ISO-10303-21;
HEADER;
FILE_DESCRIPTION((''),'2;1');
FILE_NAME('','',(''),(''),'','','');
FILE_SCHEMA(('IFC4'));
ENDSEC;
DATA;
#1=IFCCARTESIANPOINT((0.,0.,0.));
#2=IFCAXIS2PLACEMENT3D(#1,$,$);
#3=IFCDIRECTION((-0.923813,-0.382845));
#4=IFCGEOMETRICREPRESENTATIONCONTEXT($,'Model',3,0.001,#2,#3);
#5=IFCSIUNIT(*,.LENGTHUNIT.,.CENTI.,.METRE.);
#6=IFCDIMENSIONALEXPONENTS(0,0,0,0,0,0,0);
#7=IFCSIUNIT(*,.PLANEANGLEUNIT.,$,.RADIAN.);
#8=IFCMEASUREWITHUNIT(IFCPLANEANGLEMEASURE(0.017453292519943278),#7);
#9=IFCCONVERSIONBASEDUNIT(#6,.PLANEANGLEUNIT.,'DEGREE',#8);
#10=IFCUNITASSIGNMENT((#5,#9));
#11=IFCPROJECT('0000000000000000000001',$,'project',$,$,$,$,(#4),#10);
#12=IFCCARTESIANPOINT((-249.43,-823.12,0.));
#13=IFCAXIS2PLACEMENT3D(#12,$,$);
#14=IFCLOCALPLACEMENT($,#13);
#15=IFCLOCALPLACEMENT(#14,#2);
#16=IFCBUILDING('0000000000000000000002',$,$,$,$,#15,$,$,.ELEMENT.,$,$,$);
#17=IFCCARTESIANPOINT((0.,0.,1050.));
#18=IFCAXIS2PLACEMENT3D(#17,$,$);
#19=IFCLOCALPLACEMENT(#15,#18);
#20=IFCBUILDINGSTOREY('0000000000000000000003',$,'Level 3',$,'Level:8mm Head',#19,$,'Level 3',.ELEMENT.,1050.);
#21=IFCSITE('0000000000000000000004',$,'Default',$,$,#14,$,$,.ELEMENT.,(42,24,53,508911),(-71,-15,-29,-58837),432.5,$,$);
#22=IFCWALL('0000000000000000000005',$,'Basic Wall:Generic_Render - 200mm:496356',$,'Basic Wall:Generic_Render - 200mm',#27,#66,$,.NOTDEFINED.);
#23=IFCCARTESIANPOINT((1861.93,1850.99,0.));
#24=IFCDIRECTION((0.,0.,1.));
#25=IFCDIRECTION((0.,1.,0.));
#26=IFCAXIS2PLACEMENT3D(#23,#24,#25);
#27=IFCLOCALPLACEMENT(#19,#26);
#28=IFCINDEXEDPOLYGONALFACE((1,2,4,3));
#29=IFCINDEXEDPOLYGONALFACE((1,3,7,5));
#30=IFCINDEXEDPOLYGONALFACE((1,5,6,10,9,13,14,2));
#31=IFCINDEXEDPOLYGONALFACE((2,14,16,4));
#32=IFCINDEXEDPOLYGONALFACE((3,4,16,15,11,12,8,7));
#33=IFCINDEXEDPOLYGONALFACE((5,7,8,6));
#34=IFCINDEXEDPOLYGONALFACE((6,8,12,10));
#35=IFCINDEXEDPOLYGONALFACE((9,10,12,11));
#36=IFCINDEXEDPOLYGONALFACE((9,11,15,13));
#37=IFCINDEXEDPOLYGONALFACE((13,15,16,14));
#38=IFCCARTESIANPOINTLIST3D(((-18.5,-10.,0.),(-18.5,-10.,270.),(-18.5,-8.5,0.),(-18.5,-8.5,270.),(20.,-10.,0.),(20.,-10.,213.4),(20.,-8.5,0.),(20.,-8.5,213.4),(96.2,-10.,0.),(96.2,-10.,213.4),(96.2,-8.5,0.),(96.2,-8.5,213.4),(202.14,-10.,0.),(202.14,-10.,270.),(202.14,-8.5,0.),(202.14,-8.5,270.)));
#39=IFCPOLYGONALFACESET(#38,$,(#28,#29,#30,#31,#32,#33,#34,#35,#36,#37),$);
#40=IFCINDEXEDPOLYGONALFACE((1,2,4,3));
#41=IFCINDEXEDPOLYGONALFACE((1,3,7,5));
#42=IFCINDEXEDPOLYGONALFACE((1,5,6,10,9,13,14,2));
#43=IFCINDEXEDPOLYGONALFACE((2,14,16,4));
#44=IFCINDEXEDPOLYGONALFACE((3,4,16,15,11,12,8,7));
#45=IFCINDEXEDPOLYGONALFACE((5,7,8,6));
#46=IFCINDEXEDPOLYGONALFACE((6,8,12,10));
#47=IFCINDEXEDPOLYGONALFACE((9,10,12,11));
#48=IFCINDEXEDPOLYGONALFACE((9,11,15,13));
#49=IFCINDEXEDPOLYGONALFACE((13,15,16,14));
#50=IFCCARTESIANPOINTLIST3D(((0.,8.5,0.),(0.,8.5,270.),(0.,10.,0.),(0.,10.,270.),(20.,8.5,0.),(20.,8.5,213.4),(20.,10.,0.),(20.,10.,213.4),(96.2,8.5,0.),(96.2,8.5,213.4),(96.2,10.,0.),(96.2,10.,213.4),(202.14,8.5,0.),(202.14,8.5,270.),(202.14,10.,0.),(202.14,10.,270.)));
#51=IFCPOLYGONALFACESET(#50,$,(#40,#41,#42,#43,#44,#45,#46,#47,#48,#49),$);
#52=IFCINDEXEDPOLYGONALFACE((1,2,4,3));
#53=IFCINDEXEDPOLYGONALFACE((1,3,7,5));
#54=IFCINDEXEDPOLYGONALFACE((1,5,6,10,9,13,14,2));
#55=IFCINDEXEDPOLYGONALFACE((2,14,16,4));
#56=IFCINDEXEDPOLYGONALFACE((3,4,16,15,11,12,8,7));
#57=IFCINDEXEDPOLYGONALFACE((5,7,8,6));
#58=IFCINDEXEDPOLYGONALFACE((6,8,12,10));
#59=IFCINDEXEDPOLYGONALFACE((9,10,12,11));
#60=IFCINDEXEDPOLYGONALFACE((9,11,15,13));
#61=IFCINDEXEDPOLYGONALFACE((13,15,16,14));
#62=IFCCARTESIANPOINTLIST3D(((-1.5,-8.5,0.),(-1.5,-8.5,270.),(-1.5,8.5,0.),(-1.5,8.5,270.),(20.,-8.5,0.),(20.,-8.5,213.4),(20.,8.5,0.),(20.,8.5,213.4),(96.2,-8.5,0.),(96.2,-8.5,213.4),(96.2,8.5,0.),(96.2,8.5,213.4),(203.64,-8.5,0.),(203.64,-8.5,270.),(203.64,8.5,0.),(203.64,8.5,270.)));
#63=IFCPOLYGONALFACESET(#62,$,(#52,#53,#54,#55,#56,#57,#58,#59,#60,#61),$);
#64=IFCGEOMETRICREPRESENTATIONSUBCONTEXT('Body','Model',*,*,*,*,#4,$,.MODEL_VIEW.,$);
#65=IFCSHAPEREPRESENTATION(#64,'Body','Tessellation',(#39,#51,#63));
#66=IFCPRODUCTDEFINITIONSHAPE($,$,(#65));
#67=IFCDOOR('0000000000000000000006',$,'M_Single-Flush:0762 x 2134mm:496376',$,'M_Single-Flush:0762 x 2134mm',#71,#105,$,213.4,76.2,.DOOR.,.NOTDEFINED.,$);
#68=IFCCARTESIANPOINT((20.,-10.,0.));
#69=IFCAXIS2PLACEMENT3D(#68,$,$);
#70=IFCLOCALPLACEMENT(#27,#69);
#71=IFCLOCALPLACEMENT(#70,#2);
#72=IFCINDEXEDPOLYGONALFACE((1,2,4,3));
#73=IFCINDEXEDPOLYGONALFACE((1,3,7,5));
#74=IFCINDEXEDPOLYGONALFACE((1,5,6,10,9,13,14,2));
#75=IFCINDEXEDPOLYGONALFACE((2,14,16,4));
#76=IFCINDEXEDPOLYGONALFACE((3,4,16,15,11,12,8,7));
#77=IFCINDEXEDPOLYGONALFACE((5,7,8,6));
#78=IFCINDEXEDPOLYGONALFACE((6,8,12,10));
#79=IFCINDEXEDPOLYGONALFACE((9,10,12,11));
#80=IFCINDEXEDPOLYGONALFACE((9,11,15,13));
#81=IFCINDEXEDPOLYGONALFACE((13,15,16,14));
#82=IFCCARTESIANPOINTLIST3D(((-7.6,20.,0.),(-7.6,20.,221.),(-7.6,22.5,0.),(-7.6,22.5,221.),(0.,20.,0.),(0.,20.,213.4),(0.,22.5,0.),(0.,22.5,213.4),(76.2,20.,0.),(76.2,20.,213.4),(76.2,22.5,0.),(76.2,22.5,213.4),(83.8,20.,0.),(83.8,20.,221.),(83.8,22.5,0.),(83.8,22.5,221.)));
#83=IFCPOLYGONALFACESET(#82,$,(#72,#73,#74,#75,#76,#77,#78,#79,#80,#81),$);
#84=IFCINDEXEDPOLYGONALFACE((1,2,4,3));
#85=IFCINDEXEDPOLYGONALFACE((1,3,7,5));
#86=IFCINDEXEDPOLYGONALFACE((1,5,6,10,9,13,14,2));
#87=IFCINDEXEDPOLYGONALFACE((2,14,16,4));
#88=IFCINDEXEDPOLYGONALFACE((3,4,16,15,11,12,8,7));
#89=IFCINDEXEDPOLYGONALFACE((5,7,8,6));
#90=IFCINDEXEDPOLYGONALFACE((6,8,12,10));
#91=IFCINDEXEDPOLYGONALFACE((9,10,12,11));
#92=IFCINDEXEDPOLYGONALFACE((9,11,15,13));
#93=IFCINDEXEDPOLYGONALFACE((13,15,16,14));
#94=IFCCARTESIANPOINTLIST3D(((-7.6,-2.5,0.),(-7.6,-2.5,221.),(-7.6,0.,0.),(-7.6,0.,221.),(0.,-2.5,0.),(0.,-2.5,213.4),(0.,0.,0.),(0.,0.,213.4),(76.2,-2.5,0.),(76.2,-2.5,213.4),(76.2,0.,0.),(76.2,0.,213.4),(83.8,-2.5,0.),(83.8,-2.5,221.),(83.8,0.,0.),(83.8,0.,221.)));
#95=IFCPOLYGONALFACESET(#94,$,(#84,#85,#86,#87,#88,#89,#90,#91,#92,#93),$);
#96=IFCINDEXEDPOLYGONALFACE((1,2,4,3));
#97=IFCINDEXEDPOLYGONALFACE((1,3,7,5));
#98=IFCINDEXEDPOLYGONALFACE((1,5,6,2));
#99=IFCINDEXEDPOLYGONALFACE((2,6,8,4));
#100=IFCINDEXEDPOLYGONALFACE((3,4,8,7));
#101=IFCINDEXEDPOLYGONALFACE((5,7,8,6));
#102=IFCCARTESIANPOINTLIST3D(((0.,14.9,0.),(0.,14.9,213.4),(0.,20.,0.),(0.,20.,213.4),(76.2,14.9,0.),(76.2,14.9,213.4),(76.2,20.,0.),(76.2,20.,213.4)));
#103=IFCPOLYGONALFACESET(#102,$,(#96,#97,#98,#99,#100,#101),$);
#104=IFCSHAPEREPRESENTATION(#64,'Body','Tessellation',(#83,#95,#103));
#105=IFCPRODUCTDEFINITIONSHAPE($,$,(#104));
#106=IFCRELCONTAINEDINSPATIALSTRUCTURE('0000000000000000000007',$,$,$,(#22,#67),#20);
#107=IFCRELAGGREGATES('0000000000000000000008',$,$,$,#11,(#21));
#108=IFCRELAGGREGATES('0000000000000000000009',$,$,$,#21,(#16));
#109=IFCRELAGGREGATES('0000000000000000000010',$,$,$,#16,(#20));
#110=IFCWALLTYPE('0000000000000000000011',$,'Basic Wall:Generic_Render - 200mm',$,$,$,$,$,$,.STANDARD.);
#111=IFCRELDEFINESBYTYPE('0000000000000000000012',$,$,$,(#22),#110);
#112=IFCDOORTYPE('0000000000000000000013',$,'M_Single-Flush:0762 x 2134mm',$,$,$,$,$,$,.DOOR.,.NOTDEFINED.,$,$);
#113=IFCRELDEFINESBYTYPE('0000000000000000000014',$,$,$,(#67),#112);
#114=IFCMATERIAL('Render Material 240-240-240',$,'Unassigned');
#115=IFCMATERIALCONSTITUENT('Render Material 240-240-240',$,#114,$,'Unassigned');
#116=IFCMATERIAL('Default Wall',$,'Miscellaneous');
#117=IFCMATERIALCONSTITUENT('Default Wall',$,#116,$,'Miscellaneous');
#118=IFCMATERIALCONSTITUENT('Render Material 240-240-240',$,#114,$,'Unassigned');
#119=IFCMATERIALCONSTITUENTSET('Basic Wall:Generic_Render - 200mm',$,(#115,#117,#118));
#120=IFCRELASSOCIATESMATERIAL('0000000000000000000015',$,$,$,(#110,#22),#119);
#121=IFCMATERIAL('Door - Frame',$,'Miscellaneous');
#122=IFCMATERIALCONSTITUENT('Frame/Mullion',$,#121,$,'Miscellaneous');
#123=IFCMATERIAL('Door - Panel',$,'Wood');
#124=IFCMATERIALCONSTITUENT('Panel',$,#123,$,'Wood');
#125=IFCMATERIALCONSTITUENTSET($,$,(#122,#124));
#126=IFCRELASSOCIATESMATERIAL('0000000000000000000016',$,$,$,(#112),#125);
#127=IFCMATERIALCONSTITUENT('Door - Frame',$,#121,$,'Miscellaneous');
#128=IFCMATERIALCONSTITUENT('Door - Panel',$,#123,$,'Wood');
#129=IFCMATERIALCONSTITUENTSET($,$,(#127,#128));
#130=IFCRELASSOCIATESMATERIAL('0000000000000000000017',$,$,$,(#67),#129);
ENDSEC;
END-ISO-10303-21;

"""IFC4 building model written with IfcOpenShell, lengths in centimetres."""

from ifc_helpers import new_model, entity, si_unit, converted_unit, direction, frame, origin, place, context, subcontext, project, spatial, indexed_curve, outline, extrude, source, transform, mapped, material, constituent, constituent_set, type_object, type_shapes, element, fill, save


model = new_model("IFC4")

# Units and contexts
model_context = context("Model", 3, precision=0.001, world=origin(), true_north=direction((-0.923813, -0.382845)))
body_context = subcontext(model_context, "Body", "Model", "MODEL_VIEW")
ifc_project = project(units=[si_unit("LENGTHUNIT", "METRE", prefix="CENTI"), converted_unit("PLANEANGLEUNIT", "DEGREE", entity("IfcPlaneAngleMeasure", 0.017453292519943278), si_unit("PLANEANGLEUNIT", "RADIAN"), dimensions=[0, 0, 0, 0, 0, 0, 0])], contexts=[model_context])

# Site, building, storey
site_placement = place(None, frame((-249.43, -823.12, 0.0)))
site = spatial("IfcSite", under=ifc_project, at=site_placement, Name="Default", CompositionType="ELEMENT", RefLatitude=(42, 24, 53, 508911), RefLongitude=(-71, -15, -29, -58837), RefElevation=432.5)
building_placement = place(site_placement, origin())
building = spatial("IfcBuilding", under=site, at=building_placement, CompositionType="ELEMENT")
storey_placement = place(building_placement, frame((0.0, 0.0, 1050.0)))
storey = spatial("IfcBuildingStorey", under=building, at=storey_placement, Name="Level 3", ObjectType="Level:8mm Head", LongName="Level 3", CompositionType="ELEMENT", Elevation=1050.0)

# Shared definitions
ifc_material_1 = material(Name="Render Material 240-240-240", Category="Unassigned")
ifc_material_2 = material(Name="Default Wall", Category="Miscellaneous")
ifc_constituent_1 = constituent(ifc_material_1, Name="Render Material 240-240-240", Category="Unassigned")
ifc_constituent_2 = constituent(ifc_material_2, Name="Default Wall", Category="Miscellaneous")
ifc_constituent_3 = constituent(ifc_material_1, Name="Render Material 240-240-240", Category="Unassigned")
ifc_constituent_set_1 = constituent_set(constituents=[ifc_constituent_1, ifc_constituent_2, ifc_constituent_3], Name="Basic Wall:Generic_Render - 200mm")
wall_type_1 = type_object("IfcWallType", Name="Basic Wall:Generic_Render - 200mm", PredefinedType="STANDARD", material=ifc_constituent_set_1)

# Shared definitions
ifc_material_3 = material(Name="Door - Frame", Category="Miscellaneous")
ifc_material_4 = material(Name="Door - Panel", Category="Wood")

# Wall, opening, door
wall_1_placement = place(storey_placement, frame((1861.93, 1850.99, 0.0), z_axis=(0.0, 0.0, 1.0), x_axis=(0.0, 1.0, 0.0)))
wall_1 = element("IfcWall", 1, at=wall_1_placement, inside=storey, type_object=wall_type_1, material=ifc_constituent_set_1, Name="Basic Wall:Generic_Render - 200mm:496356", ObjectType="Basic Wall:Generic_Render - 200mm", PredefinedType="NOTDEFINED", context=body_context, shape_type="SweptSolid", body=[
    extrude(outline(indexed_curve([(-120.85, -127.18), (149.15, -127.18), (149.15, 93.46), (-120.85, 93.46), (-120.85, 54.96), (92.55, 54.96), (92.55, -21.24), (-120.85, -21.24), (-120.85, -127.18)], self_intersect=False)), frame((74.96, -8.5, 120.85), z_axis=(0.0, -1.0, 0.0), x_axis=(0.0, 0.0, 1.0)), (0.0, 0.0, 1.0), 1.5),
    extrude(outline(indexed_curve([(-59.58, -92.55), (-59.58, 120.85), (-79.58, 120.85), (-79.58, -149.15), (122.55, -149.15), (122.55, 120.85), (16.62, 120.85), (16.62, -92.55), (-59.58, -92.55)], self_intersect=False)), frame((79.58, 10.0, 120.85), z_axis=(0.0, 1.0, 0.0), x_axis=(1.0, 0.0, 0.0)), (0.0, 0.0, -1.0), 1.5),
    extrude(outline(indexed_curve([(-120.85, -124.05), (149.15, -124.05), (149.15, 81.08), (-120.85, 81.08), (-120.85, 59.58), (92.55, 59.58), (92.55, -16.62), (-120.85, -16.62), (-120.85, -124.05)], self_intersect=False)), frame((79.58, 8.5, 120.85), z_axis=(0.0, -1.0, 0.0), x_axis=(0.0, 0.0, 1.0)), (0.0, 0.0, 1.0), 17.0),
])
opening_1_placement = place(wall_1_placement, frame((20.0, -10.0, 0.0)))
opening_1 = element("IfcOpeningElement", 2, at=opening_1_placement, cuts=wall_1, PredefinedType="OPENING", context=body_context, shape_type="SweptSolid", body=[
    extrude(outline(indexed_curve([(0.0, 76.2), (0.0, 0.0), (213.4, 0.0), (213.4, 76.2), (0.0, 76.2)], self_intersect=False)), frame((0.0, 0.0, 0.0), z_axis=(0.0, 1.0, 0.0), x_axis=(0.0, 0.0, 1.0)), (0.0, 0.0, 1.0), 20.0),
])
ifc_constituent_4 = constituent(ifc_material_3, Name="Door - Frame", Category="Miscellaneous")
ifc_constituent_5 = constituent(ifc_material_4, Name="Door - Panel", Category="Wood")
ifc_constituent_set_2 = constituent_set(constituents=[ifc_constituent_4, ifc_constituent_5])
ifc_constituent_6 = constituent(ifc_material_3, Name="Frame/Mullion", Category="Miscellaneous")
ifc_constituent_7 = constituent(ifc_material_4, Name="Panel", Category="Wood")
ifc_constituent_set_3 = constituent_set(constituents=[ifc_constituent_6, ifc_constituent_7])
door_type_1 = type_object("IfcDoorType", Name="M_Single-Flush:0762 x 2134mm", OperationType="NOTDEFINED", PredefinedType="DOOR", material=ifc_constituent_set_3)
shared_shape_1 = source(origin(), body_context, "Body", "SweptSolid", [
    extrude(outline(indexed_curve([(-45.7, -112.4), (45.7, -112.4), (45.7, 108.6), (38.1, 108.6), (38.1, -104.8), (-38.1, -104.8), (-38.1, 108.6), (-45.7, 108.6), (-45.7, -112.4)], self_intersect=False)), frame((38.1, 22.5, 108.6), z_axis=(0.0, -1.0, 0.0), x_axis=(-1.0, 0.0, 0.0)), (0.0, 0.0, 1.0), 2.5),
    extrude(outline(indexed_curve([(-112.4, -45.7), (108.6, -45.7), (108.6, -38.1), (-104.8, -38.1), (-104.8, 38.1), (108.6, 38.1), (108.6, 45.7), (-112.4, 45.7), (-112.4, -45.7)], self_intersect=False)), frame((38.1, 0.0, 108.6), z_axis=(0.0, -1.0, 0.0), x_axis=(0.0, 0.0, -1.0)), (0.0, 0.0, 1.0), 2.5),
    extrude(outline(indexed_curve([(-38.1, -2.55), (38.1, -2.55), (38.1, 2.55), (-38.1, 2.55), (-38.1, -2.55)], self_intersect=False)), frame((38.1, 17.45, 0.0)), (0.0, 0.0, 1.0), 213.4),
])
type_shapes(door_type_1, [shared_shape_1])
door_1_placement = place(opening_1_placement, origin())
door_1 = element("IfcDoor", 3, at=door_1_placement, inside=storey, type_object=door_type_1, material=ifc_constituent_set_2, Name="M_Single-Flush:0762 x 2134mm:496376", ObjectType="M_Single-Flush:0762 x 2134mm", OperationType="NOTDEFINED", OverallHeight=213.4, OverallWidth=76.2, PredefinedType="DOOR", context=body_context, shape_type="MappedRepresentation", body=[
    mapped(shared_shape_1, transform((0.0, 0.0, 0.0), scale=1.0)),
])
fill(opening_1, door_1)

save(model, "model.ifc")
